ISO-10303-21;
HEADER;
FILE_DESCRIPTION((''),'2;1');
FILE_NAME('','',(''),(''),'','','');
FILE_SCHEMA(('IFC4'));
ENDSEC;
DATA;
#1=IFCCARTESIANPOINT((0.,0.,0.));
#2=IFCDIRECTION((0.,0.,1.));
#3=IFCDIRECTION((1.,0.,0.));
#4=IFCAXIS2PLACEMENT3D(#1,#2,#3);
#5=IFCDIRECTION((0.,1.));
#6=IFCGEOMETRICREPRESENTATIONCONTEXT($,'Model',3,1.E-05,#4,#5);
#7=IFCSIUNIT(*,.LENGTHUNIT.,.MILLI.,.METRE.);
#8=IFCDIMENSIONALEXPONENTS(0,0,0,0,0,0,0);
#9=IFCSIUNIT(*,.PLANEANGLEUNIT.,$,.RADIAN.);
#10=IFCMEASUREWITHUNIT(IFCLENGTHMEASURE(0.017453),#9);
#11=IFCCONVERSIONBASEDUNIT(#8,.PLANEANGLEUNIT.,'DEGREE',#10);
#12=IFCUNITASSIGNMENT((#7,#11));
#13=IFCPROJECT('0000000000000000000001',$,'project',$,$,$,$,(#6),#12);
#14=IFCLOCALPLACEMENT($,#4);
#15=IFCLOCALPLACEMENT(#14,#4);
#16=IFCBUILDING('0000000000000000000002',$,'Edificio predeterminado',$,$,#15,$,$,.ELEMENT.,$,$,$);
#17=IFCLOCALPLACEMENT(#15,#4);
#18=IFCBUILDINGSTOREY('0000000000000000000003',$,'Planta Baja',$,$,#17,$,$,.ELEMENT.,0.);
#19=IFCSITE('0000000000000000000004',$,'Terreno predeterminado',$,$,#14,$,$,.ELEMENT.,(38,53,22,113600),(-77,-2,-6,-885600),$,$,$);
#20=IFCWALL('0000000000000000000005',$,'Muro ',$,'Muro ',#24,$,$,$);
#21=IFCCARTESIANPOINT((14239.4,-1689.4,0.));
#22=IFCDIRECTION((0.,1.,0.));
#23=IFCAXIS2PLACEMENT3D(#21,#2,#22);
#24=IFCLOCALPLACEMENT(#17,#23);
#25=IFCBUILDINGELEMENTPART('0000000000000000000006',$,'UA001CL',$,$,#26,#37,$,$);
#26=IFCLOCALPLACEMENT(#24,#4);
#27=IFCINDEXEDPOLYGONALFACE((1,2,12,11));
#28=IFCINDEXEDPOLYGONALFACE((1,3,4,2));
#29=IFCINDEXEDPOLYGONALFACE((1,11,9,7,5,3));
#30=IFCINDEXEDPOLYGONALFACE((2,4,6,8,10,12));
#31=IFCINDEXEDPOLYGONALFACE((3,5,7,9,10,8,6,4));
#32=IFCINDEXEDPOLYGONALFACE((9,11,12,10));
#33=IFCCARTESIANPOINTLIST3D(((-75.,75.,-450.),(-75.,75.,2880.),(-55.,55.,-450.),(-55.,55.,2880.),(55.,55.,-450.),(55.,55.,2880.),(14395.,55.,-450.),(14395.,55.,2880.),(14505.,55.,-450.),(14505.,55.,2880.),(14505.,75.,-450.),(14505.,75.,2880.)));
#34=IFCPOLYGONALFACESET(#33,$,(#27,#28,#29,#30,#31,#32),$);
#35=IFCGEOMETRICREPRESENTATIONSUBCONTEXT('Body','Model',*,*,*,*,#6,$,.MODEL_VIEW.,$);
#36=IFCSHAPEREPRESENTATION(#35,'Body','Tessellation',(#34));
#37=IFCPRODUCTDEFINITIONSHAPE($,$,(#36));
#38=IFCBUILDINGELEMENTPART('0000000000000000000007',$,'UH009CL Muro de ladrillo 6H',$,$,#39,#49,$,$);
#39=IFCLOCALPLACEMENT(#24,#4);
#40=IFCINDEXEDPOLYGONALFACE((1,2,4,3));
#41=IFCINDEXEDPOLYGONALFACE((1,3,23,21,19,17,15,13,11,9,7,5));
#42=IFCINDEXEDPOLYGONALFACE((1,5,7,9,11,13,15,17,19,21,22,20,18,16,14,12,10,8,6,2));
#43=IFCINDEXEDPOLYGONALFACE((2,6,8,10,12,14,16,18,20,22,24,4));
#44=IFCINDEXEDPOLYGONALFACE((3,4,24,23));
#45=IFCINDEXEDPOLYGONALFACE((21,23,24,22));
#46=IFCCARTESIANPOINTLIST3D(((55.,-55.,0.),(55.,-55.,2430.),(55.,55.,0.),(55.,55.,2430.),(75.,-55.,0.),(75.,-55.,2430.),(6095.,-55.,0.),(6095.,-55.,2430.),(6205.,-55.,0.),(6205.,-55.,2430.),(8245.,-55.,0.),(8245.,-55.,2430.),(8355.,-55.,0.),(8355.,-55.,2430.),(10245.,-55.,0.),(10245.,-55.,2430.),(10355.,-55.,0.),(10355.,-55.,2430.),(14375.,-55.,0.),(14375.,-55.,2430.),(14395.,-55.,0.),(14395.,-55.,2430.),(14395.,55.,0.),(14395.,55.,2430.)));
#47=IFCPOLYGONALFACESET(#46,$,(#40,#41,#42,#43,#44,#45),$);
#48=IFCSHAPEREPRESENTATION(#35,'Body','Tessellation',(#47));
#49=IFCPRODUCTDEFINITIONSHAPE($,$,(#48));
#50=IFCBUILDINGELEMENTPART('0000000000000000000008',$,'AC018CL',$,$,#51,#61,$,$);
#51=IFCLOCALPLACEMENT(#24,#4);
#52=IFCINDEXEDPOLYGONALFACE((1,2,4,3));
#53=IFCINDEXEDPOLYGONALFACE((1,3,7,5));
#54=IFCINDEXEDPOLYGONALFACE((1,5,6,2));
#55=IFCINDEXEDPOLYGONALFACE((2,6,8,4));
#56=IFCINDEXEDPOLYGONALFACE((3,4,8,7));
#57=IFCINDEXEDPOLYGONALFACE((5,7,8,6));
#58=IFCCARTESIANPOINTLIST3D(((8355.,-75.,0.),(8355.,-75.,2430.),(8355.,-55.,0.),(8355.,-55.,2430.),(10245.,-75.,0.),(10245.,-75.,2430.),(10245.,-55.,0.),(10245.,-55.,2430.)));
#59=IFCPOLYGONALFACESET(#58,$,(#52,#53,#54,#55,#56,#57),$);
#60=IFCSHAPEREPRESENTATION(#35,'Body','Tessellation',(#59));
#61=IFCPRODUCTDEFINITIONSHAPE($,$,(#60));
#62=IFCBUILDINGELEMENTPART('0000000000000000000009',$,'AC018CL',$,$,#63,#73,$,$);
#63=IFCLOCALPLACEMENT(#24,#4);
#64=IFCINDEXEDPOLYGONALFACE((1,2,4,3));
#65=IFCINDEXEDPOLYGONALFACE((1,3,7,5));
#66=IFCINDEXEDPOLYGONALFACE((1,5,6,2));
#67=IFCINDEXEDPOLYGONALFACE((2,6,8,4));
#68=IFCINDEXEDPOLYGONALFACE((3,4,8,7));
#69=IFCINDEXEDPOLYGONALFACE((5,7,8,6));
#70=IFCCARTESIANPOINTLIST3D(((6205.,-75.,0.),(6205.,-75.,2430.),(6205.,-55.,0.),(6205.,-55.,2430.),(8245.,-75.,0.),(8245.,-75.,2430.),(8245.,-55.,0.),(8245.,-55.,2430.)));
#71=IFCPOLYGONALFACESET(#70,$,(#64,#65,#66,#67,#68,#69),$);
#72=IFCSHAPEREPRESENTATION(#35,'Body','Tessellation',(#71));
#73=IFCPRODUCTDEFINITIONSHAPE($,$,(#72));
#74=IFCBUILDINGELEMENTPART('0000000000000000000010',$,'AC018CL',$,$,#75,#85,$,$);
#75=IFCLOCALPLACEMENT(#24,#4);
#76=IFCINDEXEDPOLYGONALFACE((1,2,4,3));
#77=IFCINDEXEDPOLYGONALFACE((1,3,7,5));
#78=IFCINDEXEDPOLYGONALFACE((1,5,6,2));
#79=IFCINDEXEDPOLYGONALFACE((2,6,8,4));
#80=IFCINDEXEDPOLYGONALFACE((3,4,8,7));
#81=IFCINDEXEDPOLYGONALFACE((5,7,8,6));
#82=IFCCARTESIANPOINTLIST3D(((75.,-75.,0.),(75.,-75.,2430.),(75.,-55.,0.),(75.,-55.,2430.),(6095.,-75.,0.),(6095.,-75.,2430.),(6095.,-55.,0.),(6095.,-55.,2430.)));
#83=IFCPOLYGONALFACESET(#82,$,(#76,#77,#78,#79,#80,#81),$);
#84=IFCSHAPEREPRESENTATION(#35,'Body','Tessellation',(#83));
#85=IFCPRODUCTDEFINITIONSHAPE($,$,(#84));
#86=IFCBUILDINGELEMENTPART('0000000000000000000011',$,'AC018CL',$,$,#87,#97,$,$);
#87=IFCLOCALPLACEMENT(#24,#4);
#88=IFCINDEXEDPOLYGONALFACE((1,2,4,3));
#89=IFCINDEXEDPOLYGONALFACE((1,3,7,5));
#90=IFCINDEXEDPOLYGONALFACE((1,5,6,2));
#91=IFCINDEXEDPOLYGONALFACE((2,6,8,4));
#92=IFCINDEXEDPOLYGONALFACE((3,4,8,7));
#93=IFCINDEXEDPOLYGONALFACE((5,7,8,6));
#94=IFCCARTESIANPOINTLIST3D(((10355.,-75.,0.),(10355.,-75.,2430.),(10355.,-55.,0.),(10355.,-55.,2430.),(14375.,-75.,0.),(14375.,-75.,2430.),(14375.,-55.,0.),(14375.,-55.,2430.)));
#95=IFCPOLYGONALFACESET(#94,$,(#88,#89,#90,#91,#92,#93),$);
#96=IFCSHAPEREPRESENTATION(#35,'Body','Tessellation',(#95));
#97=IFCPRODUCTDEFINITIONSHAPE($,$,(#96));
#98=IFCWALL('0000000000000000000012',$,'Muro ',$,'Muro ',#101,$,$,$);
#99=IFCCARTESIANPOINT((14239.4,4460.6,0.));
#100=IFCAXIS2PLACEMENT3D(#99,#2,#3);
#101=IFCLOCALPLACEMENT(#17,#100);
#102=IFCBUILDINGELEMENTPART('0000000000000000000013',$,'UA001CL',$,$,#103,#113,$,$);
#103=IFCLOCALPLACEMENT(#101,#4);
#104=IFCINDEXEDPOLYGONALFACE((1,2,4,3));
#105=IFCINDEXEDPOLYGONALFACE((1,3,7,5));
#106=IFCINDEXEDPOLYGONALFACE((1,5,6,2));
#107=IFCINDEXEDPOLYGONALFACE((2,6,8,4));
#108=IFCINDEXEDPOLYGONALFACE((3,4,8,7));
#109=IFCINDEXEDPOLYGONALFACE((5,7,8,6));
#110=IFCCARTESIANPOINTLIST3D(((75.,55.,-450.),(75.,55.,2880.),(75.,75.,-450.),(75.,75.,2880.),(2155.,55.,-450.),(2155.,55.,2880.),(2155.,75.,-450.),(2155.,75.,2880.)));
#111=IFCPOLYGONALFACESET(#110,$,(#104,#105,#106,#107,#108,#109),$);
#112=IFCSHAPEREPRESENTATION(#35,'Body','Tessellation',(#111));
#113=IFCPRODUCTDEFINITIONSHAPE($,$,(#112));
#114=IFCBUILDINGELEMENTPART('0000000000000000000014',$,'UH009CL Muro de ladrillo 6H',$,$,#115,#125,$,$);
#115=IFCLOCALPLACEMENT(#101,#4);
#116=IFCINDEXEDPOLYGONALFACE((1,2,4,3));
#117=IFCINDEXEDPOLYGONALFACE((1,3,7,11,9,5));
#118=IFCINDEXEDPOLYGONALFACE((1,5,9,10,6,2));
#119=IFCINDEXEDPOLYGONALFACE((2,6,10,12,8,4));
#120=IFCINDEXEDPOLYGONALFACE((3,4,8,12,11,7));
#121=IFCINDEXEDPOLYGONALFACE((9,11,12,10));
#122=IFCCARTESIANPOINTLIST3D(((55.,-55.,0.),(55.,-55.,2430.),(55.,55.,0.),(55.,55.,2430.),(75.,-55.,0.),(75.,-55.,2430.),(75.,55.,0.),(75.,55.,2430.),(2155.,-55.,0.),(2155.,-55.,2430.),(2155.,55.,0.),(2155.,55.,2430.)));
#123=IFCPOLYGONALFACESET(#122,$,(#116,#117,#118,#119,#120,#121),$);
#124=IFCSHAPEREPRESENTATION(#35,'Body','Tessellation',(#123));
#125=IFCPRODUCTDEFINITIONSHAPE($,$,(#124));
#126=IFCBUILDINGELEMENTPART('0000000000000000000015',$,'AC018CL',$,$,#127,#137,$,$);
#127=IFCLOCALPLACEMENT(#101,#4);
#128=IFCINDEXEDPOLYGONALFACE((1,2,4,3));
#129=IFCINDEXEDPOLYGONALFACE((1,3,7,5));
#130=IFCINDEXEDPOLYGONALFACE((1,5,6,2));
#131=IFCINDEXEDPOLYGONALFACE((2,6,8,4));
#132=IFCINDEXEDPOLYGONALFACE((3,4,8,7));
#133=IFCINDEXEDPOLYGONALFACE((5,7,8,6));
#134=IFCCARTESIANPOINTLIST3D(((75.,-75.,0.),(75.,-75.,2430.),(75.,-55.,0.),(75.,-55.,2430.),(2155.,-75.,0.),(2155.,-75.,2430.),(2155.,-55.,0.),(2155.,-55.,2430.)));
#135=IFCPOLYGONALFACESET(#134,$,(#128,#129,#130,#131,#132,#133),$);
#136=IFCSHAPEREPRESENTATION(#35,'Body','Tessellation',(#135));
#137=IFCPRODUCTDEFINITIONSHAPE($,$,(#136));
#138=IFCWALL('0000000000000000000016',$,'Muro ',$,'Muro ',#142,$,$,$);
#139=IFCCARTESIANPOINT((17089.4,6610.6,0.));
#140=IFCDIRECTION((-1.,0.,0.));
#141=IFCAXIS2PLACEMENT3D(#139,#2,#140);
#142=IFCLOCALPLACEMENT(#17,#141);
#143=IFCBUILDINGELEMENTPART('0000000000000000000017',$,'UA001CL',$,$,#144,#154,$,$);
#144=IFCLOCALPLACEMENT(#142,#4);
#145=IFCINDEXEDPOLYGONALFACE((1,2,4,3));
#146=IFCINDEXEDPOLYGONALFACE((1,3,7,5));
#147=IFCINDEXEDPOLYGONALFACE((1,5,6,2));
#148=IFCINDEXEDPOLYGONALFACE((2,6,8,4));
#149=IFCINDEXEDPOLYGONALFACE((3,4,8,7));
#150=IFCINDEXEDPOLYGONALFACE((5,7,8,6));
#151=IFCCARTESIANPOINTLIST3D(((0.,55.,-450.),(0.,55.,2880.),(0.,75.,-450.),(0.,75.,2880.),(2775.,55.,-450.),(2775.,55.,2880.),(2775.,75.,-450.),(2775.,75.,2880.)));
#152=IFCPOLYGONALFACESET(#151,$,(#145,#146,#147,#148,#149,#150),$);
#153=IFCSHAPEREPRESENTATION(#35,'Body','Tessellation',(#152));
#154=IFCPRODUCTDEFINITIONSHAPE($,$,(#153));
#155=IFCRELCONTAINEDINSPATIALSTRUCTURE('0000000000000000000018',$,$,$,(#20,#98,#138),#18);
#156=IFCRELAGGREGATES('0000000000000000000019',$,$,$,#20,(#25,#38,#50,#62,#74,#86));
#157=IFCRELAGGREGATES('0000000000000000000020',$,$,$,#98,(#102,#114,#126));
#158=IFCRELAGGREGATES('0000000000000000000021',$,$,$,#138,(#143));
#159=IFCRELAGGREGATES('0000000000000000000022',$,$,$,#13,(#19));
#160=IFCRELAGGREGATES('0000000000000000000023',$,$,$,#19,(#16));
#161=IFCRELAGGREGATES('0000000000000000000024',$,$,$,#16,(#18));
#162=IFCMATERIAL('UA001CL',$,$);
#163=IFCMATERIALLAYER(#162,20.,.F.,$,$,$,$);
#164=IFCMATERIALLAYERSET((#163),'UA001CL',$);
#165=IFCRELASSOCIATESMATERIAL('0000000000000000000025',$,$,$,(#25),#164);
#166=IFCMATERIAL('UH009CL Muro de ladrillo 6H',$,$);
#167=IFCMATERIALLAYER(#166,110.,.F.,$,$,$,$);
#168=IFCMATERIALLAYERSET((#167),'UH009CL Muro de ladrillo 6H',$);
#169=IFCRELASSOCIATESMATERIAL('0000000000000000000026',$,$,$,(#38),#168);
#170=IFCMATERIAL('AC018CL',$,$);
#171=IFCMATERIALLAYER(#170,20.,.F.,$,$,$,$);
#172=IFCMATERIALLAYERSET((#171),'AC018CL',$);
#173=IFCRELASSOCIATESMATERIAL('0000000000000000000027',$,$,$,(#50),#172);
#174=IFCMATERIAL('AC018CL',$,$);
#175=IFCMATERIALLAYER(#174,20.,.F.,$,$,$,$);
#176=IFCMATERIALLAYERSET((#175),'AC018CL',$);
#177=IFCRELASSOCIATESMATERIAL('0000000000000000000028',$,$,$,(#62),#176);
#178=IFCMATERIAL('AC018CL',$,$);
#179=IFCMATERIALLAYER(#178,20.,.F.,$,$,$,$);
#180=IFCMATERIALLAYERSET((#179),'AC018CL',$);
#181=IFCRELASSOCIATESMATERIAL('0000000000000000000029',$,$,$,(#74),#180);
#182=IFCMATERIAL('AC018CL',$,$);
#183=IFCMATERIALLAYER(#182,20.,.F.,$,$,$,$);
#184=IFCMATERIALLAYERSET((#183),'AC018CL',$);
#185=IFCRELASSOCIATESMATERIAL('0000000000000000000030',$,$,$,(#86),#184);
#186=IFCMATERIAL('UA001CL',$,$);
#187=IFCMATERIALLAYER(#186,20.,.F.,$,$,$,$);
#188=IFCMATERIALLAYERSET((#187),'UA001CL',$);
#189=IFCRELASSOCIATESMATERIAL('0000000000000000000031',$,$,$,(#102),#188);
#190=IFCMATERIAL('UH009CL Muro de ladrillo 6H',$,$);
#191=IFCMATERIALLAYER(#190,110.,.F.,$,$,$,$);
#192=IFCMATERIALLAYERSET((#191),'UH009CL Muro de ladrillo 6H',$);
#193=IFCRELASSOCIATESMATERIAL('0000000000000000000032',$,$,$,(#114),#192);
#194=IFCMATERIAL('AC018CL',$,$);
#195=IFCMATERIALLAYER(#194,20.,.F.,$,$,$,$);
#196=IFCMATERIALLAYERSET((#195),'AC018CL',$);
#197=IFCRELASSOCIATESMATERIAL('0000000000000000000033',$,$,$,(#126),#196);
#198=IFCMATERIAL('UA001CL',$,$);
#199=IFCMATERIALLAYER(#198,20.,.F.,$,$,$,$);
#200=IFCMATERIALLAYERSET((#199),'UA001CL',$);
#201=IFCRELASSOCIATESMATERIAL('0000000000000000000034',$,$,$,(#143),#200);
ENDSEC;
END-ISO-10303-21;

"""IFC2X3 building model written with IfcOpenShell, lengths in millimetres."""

from ifc_helpers import new_model, entity, si_unit, converted_unit, direction, frame, origin_with_axes, place, context, subcontext, project, spatial, polyline, outline, extrude, material, layer, layer_set, layer_usage, element, aggregate, save


model = new_model("IFC2X3")

# Units and contexts
model_context = context("Model", 3, precision=1e-05, world=origin_with_axes(), true_north=direction((0.0, 1.0)))
body_context = subcontext(model_context, "Body", "Model", "MODEL_VIEW")
ifc_project = project(units=[si_unit("LENGTHUNIT", "METRE", prefix="MILLI"), converted_unit("PLANEANGLEUNIT", "DEGREE", entity("IfcLengthMeasure", 0.017453), si_unit("PLANEANGLEUNIT", "RADIAN"), dimensions=[0, 0, 0, 0, 0, 0, 0])], contexts=[model_context])

# Site, building, storey
site_placement = place(None, origin_with_axes())
site = spatial("IfcSite", under=ifc_project, at=site_placement, Name="Terreno predeterminado", CompositionType="ELEMENT", RefLatitude=(38, 53, 22, 113600), RefLongitude=(-77, -2, -6, -885600))
building_placement = place(site_placement, origin_with_axes())
building = spatial("IfcBuilding", under=site, at=building_placement, Name="Edificio predeterminado", CompositionType="ELEMENT")
storey_placement = place(building_placement, origin_with_axes())
storey = spatial("IfcBuildingStorey", under=building, at=storey_placement, Name="Planta Baja", CompositionType="ELEMENT", Elevation=0.0)

# Walls, building element parts
wall_1_placement = place(storey_placement, frame((14239.4, -1689.4, 0.0), z_axis=(0.0, 0.0, 1.0), x_axis=(0.0, 1.0, 0.0)))
wall_1 = element("IfcWall", 1, at=wall_1_placement, inside=storey, Name="Muro ", ObjectType="Muro ")
ifc_material_1 = material(Name="UA001CL")
ifc_layer_1 = layer(ifc_material_1, 20.0, ventilated=False)
ifc_layer_set_1 = layer_set([ifc_layer_1], Name="UA001CL")
ifc_layer_usage_1 = layer_usage(ifc_layer_set_1, "AXIS2", "NEGATIVE", -75.0)
building_element_part_1_placement = place(wall_1_placement, origin_with_axes())
building_element_part_1 = element("IfcBuildingElementPart", 2, at=building_element_part_1_placement, material=ifc_layer_usage_1, Name="UA001CL", context=body_context, shape_type="SweptSolid", body=[
    extrude(outline(polyline([(14505.0, 75.0), (14505.0, 55.0), (14395.0, 55.0), (55.0, 55.0), (-55.0, 55.0), (-75.0, 75.0), (14505.0, 75.0)])), frame((0.0, 0.0, -450.0), z_axis=(0.0, 0.0, 1.0), x_axis=(1.0, 0.0, 0.0)), (0.0, 0.0, 1.0), 3330.0),
])
ifc_material_2 = material(Name="UH009CL Muro de ladrillo 6H")
ifc_layer_2 = layer(ifc_material_2, 110.0, ventilated=False)
ifc_layer_set_2 = layer_set([ifc_layer_2], Name="UH009CL Muro de ladrillo 6H")
ifc_layer_usage_2 = layer_usage(ifc_layer_set_2, "AXIS2", "NEGATIVE", -55.0)
building_element_part_2_placement = place(wall_1_placement, origin_with_axes())
building_element_part_2 = element("IfcBuildingElementPart", 3, at=building_element_part_2_placement, material=ifc_layer_usage_2, Name="UH009CL Muro de ladrillo 6H", context=body_context, shape_type="SweptSolid", body=[
    extrude(outline(polyline([(14395.0, 55.0), (14395.0, -55.0), (14375.0, -55.0), (10355.0, -55.0), (10245.0, -55.0), (8355.0, -55.0), (8245.0, -55.0), (6205.0, -55.0), (6095.0, -55.0), (75.0, -55.0), (55.0, -55.0), (55.0, 55.0), (14395.0, 55.0)])), origin_with_axes(), (0.0, 0.0, 1.0), 2430.0),
])
ifc_material_3 = material(Name="AC018CL")
ifc_layer_3 = layer(ifc_material_3, 20.0, ventilated=False)
ifc_layer_set_3 = layer_set([ifc_layer_3], Name="AC018CL")
ifc_layer_usage_3 = layer_usage(ifc_layer_set_3, "AXIS2", "NEGATIVE", 55.0)
building_element_part_3_placement = place(wall_1_placement, origin_with_axes())
building_element_part_3 = element("IfcBuildingElementPart", 4, at=building_element_part_3_placement, material=ifc_layer_usage_3, Name="AC018CL", context=body_context, shape_type="SweptSolid", body=[
    extrude(outline(polyline([(8355.0, -55.0), (10245.0, -55.0), (10245.0, -75.0), (8355.0, -75.0), (8355.0, -55.0)])), origin_with_axes(), (0.0, 0.0, 1.0), 2430.0),
])
ifc_material_4 = material(Name="AC018CL")
ifc_layer_4 = layer(ifc_material_4, 20.0, ventilated=False)
ifc_layer_set_4 = layer_set([ifc_layer_4], Name="AC018CL")
ifc_layer_usage_4 = layer_usage(ifc_layer_set_4, "AXIS2", "NEGATIVE", 55.0)
building_element_part_4_placement = place(wall_1_placement, origin_with_axes())
building_element_part_4 = element("IfcBuildingElementPart", 5, at=building_element_part_4_placement, material=ifc_layer_usage_4, Name="AC018CL", context=body_context, shape_type="SweptSolid", body=[
    extrude(outline(polyline([(8245.0, -55.0), (8245.0, -75.0), (6205.0, -75.0), (6205.0, -55.0), (8245.0, -55.0)])), origin_with_axes(), (0.0, 0.0, 1.0), 2430.0),
])
ifc_material_5 = material(Name="AC018CL")
ifc_layer_5 = layer(ifc_material_5, 20.0, ventilated=False)
ifc_layer_set_5 = layer_set([ifc_layer_5], Name="AC018CL")
ifc_layer_usage_5 = layer_usage(ifc_layer_set_5, "AXIS2", "NEGATIVE", 55.0)
building_element_part_5_placement = place(wall_1_placement, origin_with_axes())
building_element_part_5 = element("IfcBuildingElementPart", 6, at=building_element_part_5_placement, material=ifc_layer_usage_5, Name="AC018CL", context=body_context, shape_type="SweptSolid", body=[
    extrude(outline(polyline([(6095.0, -55.0), (6095.0, -75.0), (75.0, -75.0), (75.0, -55.0), (6095.0, -55.0)])), origin_with_axes(), (0.0, 0.0, 1.0), 2430.0),
])
ifc_material_6 = material(Name="AC018CL")
ifc_layer_6 = layer(ifc_material_6, 20.0, ventilated=False)
ifc_layer_set_6 = layer_set([ifc_layer_6], Name="AC018CL")
ifc_layer_usage_6 = layer_usage(ifc_layer_set_6, "AXIS2", "NEGATIVE", 55.0)
building_element_part_6_placement = place(wall_1_placement, origin_with_axes())
building_element_part_6 = element("IfcBuildingElementPart", 7, at=building_element_part_6_placement, material=ifc_layer_usage_6, Name="AC018CL", context=body_context, shape_type="SweptSolid", body=[
    extrude(outline(polyline([(14375.0, -55.0), (14375.0, -75.0), (10355.0, -75.0), (10355.0, -55.0), (14375.0, -55.0)])), origin_with_axes(), (0.0, 0.0, 1.0), 2430.0),
])
aggregate(wall_1, [building_element_part_1, building_element_part_2, building_element_part_3, building_element_part_4, building_element_part_5, building_element_part_6])
wall_2_placement = place(storey_placement, frame((14239.4, 4460.6, 0.0), z_axis=(0.0, 0.0, 1.0), x_axis=(1.0, 0.0, 0.0)))
wall_2 = element("IfcWall", 8, at=wall_2_placement, inside=storey, Name="Muro ", ObjectType="Muro ")
ifc_material_7 = material(Name="UA001CL")
ifc_layer_7 = layer(ifc_material_7, 20.0, ventilated=False)
ifc_layer_set_7 = layer_set([ifc_layer_7], Name="UA001CL")
ifc_layer_usage_7 = layer_usage(ifc_layer_set_7, "AXIS2", "NEGATIVE", -75.0)
building_element_part_7_placement = place(wall_2_placement, origin_with_axes())
building_element_part_7 = element("IfcBuildingElementPart", 9, at=building_element_part_7_placement, material=ifc_layer_usage_7, Name="UA001CL", context=body_context, shape_type="SweptSolid", body=[
    extrude(outline(polyline([(2155.0, 75.0), (2155.0, 55.0), (75.0, 55.0), (75.0, 75.0), (2155.0, 75.0)])), frame((0.0, 0.0, -450.0), z_axis=(0.0, 0.0, 1.0), x_axis=(1.0, 0.0, 0.0)), (0.0, 0.0, 1.0), 3330.0),
])
ifc_material_8 = material(Name="UH009CL Muro de ladrillo 6H")
ifc_layer_8 = layer(ifc_material_8, 110.0, ventilated=False)
ifc_layer_set_8 = layer_set([ifc_layer_8], Name="UH009CL Muro de ladrillo 6H")
ifc_layer_usage_8 = layer_usage(ifc_layer_set_8, "AXIS2", "NEGATIVE", -55.0)
building_element_part_8_placement = place(wall_2_placement, origin_with_axes())
building_element_part_8 = element("IfcBuildingElementPart", 10, at=building_element_part_8_placement, material=ifc_layer_usage_8, Name="UH009CL Muro de ladrillo 6H", context=body_context, shape_type="SweptSolid", body=[
    extrude(outline(polyline([(2155.0, 55.0), (2155.0, -55.0), (75.0, -55.0), (55.0, -55.0), (55.0, 55.0), (75.0, 55.0), (2155.0, 55.0)])), origin_with_axes(), (0.0, 0.0, 1.0), 2430.0),
])
ifc_material_9 = material(Name="AC018CL")
ifc_layer_9 = layer(ifc_material_9, 20.0, ventilated=False)
ifc_layer_set_9 = layer_set([ifc_layer_9], Name="AC018CL")
ifc_layer_usage_9 = layer_usage(ifc_layer_set_9, "AXIS2", "NEGATIVE", 55.0)
building_element_part_9_placement = place(wall_2_placement, origin_with_axes())
building_element_part_9 = element("IfcBuildingElementPart", 11, at=building_element_part_9_placement, material=ifc_layer_usage_9, Name="AC018CL", context=body_context, shape_type="SweptSolid", body=[
    extrude(outline(polyline([(2155.0, -55.0), (2155.0, -75.0), (75.0, -75.0), (75.0, -55.0), (2155.0, -55.0)])), origin_with_axes(), (0.0, 0.0, 1.0), 2430.0),
])
aggregate(wall_2, [building_element_part_7, building_element_part_8, building_element_part_9])

# Wall, building element part
wall_3_placement = place(storey_placement, frame((17089.4, 6610.6, 0.0), z_axis=(0.0, 0.0, 1.0), x_axis=(-1.0, 0.0, 0.0)))
wall_3 = element("IfcWall", 12, at=wall_3_placement, inside=storey, Name="Muro ", ObjectType="Muro ")
ifc_material_10 = material(Name="UA001CL")
ifc_layer_10 = layer(ifc_material_10, 20.0, ventilated=False)
ifc_layer_set_10 = layer_set([ifc_layer_10], Name="UA001CL")
ifc_layer_usage_10 = layer_usage(ifc_layer_set_10, "AXIS2", "NEGATIVE", -75.0)
building_element_part_10_placement = place(wall_3_placement, origin_with_axes())
building_element_part_10 = element("IfcBuildingElementPart", 13, at=building_element_part_10_placement, material=ifc_layer_usage_10, Name="UA001CL", context=body_context, shape_type="SweptSolid", body=[
    extrude(outline(polyline([(0.0, 75.0), (2775.0, 75.0), (2775.0, 55.0), (0.0, 55.0), (0.0, 75.0)])), frame((0.0, 0.0, -450.0), z_axis=(0.0, 0.0, 1.0), x_axis=(1.0, 0.0, 0.0)), (0.0, 0.0, 1.0), 3330.0),
])
aggregate(wall_3, [building_element_part_10])

save(model, "model.ifc")
